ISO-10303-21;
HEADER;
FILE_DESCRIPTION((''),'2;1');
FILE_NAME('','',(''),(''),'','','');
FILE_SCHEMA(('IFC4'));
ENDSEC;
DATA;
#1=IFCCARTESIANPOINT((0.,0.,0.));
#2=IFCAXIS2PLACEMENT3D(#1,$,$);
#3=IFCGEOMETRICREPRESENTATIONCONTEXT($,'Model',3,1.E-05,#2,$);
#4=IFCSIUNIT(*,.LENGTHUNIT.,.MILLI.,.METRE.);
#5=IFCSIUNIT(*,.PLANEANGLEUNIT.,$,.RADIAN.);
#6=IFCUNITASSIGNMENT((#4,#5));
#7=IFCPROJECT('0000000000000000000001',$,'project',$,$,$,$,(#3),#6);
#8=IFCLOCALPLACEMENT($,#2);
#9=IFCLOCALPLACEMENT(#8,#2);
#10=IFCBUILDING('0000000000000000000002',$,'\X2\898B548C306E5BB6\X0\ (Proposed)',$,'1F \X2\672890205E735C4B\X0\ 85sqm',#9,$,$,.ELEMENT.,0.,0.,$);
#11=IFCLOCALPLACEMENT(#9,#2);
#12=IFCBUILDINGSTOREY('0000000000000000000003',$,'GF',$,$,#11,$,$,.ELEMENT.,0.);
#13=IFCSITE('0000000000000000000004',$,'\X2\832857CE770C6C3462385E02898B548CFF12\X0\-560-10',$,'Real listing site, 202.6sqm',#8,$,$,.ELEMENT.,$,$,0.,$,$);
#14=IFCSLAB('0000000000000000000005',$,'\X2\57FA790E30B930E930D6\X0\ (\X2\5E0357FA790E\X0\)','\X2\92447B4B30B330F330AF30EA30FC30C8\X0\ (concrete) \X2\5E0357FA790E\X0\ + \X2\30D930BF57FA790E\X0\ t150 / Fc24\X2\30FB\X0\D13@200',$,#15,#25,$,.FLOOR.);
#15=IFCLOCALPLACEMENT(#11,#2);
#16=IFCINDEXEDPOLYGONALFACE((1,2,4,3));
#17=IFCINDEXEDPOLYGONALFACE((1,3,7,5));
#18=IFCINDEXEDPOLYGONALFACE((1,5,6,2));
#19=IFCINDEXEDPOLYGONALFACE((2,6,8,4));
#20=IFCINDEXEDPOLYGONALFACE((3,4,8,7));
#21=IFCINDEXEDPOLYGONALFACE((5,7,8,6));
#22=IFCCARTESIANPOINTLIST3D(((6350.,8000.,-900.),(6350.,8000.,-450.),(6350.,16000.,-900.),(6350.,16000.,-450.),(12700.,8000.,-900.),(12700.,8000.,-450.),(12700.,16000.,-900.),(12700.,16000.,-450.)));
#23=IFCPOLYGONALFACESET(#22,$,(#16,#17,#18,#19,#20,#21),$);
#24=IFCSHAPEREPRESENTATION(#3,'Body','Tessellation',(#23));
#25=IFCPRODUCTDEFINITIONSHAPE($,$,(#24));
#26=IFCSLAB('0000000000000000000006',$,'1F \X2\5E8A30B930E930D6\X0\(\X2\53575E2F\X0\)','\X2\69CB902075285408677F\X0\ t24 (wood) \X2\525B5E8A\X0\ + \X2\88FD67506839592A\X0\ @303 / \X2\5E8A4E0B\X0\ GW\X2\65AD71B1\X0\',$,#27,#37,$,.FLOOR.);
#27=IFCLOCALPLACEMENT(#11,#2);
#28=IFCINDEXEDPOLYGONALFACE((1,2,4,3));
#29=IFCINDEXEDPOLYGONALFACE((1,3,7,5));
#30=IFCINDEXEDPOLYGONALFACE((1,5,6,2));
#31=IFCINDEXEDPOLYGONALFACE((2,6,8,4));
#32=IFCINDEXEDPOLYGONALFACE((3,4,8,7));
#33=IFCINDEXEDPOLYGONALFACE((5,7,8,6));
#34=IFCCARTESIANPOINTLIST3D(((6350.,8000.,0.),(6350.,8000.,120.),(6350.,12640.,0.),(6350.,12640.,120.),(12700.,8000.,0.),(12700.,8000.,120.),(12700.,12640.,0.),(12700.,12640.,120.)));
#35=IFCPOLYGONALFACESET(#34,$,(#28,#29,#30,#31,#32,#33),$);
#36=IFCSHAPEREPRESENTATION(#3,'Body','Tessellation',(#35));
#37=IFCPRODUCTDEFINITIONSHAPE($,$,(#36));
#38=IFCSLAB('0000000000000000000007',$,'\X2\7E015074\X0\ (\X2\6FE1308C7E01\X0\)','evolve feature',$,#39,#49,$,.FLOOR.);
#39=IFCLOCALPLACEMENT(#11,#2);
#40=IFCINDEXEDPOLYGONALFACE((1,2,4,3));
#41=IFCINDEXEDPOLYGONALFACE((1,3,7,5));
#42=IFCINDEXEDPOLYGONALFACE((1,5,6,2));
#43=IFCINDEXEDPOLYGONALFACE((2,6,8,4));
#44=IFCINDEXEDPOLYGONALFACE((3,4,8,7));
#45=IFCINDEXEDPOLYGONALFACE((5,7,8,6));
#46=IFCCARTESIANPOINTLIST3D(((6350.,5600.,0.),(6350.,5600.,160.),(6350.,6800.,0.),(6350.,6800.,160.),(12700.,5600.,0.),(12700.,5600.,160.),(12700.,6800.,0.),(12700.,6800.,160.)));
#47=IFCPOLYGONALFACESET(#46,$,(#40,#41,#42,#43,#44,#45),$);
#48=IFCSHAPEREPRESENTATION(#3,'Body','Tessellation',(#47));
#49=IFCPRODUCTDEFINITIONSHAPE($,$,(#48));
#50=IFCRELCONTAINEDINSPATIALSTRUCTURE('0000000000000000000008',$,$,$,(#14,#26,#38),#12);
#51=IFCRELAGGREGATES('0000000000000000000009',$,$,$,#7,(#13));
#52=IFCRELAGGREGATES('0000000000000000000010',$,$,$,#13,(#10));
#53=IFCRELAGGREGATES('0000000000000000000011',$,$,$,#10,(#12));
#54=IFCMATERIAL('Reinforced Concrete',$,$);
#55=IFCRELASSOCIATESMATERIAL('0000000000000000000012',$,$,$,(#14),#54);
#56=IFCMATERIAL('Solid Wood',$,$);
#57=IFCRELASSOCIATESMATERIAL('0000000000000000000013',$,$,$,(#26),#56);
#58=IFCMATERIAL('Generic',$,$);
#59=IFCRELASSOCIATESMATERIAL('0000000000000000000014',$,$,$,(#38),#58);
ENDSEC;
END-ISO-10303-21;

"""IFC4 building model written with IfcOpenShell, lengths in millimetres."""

from ifc_helpers import new_model, si_unit, frame, frame_2d, origin, place, context, project, spatial, rectangle, extrude, material, element, save


model = new_model("IFC4")

# Units and contexts
model_context = context("Model", 3, precision=1e-05, world=origin())
ifc_project = project(units=[si_unit("LENGTHUNIT", "METRE", prefix="MILLI"), si_unit("PLANEANGLEUNIT", "RADIAN")], contexts=[model_context])

# Site, building, storey
site_placement = place(None, origin())
site = spatial("IfcSite", under=ifc_project, at=site_placement, Name="茨城県水戸市見和２-560-10", ObjectType="Real listing site, 202.6sqm", CompositionType="ELEMENT", RefElevation=0.0)
building_placement = place(site_placement, origin())
building = spatial("IfcBuilding", under=site, at=building_placement, Name="見和の家 (Proposed)", ObjectType="1F 木造平屋 85sqm", CompositionType="ELEMENT", ElevationOfRefHeight=0.0, ElevationOfTerrain=0.0)
storey_placement = place(building_placement, origin())
storey = spatial("IfcBuildingStorey", under=building, at=storey_placement, Name="GF", CompositionType="ELEMENT", Elevation=0.0)

# Slabs
ifc_material_1 = material(Name="Reinforced Concrete")
slab_1_placement = place(storey_placement, frame((3175.0, 4000.0, -450.0)))
element("IfcSlab", 1, at=slab_1_placement, inside=storey, material=ifc_material_1, Name="基礎スラブ (布基礎)", Description="鉄筋コンクリート (concrete) 布基礎 + ベタ基礎 t150 / Fc24・D13@200", PredefinedType="FLOOR", context=model_context, shape_type="SweptSolid", body=[
    extrude(rectangle(XDim=6350.0, YDim=8000.0, at=frame_2d((3175.0, 4000.0))), frame((3175.0, 4000.0, -450.0)), (0.0, 0.0, 1.0), 450.0),
])
ifc_material_2 = material(Name="Solid Wood")
slab_2_placement = place(storey_placement, frame((3175.0, 4000.0, 0.0)))
element("IfcSlab", 2, at=slab_2_placement, inside=storey, material=ifc_material_2, Name="1F 床スラブ(南帯)", Description="構造用合板 t24 (wood) 剛床 + 製材根太 @303 / 床下 GW断熱", PredefinedType="FLOOR", context=model_context, shape_type="SweptSolid", body=[
    extrude(rectangle(XDim=6350.0, YDim=4640.0, at=frame_2d((3175.0, 2320.0))), frame((3175.0, 4000.0, 0.0)), (0.0, 0.0, 1.0), 120.0),
])
ifc_material_3 = material(Name="Generic")
slab_3_placement = place(storey_placement, frame((3175.0, 2800.0, 0.0)))
element("IfcSlab", 3, at=slab_3_placement, inside=storey, material=ifc_material_3, Name="縁側 (濡れ縁)", Description="evolve feature", PredefinedType="FLOOR", context=model_context, shape_type="SweptSolid", body=[
    extrude(rectangle(XDim=6350.0, YDim=1200.0, at=frame_2d((3175.0, 600.0))), frame((3175.0, 2800.0, 0.0)), (0.0, 0.0, 1.0), 160.0),
])

save(model, "model.ifc")
